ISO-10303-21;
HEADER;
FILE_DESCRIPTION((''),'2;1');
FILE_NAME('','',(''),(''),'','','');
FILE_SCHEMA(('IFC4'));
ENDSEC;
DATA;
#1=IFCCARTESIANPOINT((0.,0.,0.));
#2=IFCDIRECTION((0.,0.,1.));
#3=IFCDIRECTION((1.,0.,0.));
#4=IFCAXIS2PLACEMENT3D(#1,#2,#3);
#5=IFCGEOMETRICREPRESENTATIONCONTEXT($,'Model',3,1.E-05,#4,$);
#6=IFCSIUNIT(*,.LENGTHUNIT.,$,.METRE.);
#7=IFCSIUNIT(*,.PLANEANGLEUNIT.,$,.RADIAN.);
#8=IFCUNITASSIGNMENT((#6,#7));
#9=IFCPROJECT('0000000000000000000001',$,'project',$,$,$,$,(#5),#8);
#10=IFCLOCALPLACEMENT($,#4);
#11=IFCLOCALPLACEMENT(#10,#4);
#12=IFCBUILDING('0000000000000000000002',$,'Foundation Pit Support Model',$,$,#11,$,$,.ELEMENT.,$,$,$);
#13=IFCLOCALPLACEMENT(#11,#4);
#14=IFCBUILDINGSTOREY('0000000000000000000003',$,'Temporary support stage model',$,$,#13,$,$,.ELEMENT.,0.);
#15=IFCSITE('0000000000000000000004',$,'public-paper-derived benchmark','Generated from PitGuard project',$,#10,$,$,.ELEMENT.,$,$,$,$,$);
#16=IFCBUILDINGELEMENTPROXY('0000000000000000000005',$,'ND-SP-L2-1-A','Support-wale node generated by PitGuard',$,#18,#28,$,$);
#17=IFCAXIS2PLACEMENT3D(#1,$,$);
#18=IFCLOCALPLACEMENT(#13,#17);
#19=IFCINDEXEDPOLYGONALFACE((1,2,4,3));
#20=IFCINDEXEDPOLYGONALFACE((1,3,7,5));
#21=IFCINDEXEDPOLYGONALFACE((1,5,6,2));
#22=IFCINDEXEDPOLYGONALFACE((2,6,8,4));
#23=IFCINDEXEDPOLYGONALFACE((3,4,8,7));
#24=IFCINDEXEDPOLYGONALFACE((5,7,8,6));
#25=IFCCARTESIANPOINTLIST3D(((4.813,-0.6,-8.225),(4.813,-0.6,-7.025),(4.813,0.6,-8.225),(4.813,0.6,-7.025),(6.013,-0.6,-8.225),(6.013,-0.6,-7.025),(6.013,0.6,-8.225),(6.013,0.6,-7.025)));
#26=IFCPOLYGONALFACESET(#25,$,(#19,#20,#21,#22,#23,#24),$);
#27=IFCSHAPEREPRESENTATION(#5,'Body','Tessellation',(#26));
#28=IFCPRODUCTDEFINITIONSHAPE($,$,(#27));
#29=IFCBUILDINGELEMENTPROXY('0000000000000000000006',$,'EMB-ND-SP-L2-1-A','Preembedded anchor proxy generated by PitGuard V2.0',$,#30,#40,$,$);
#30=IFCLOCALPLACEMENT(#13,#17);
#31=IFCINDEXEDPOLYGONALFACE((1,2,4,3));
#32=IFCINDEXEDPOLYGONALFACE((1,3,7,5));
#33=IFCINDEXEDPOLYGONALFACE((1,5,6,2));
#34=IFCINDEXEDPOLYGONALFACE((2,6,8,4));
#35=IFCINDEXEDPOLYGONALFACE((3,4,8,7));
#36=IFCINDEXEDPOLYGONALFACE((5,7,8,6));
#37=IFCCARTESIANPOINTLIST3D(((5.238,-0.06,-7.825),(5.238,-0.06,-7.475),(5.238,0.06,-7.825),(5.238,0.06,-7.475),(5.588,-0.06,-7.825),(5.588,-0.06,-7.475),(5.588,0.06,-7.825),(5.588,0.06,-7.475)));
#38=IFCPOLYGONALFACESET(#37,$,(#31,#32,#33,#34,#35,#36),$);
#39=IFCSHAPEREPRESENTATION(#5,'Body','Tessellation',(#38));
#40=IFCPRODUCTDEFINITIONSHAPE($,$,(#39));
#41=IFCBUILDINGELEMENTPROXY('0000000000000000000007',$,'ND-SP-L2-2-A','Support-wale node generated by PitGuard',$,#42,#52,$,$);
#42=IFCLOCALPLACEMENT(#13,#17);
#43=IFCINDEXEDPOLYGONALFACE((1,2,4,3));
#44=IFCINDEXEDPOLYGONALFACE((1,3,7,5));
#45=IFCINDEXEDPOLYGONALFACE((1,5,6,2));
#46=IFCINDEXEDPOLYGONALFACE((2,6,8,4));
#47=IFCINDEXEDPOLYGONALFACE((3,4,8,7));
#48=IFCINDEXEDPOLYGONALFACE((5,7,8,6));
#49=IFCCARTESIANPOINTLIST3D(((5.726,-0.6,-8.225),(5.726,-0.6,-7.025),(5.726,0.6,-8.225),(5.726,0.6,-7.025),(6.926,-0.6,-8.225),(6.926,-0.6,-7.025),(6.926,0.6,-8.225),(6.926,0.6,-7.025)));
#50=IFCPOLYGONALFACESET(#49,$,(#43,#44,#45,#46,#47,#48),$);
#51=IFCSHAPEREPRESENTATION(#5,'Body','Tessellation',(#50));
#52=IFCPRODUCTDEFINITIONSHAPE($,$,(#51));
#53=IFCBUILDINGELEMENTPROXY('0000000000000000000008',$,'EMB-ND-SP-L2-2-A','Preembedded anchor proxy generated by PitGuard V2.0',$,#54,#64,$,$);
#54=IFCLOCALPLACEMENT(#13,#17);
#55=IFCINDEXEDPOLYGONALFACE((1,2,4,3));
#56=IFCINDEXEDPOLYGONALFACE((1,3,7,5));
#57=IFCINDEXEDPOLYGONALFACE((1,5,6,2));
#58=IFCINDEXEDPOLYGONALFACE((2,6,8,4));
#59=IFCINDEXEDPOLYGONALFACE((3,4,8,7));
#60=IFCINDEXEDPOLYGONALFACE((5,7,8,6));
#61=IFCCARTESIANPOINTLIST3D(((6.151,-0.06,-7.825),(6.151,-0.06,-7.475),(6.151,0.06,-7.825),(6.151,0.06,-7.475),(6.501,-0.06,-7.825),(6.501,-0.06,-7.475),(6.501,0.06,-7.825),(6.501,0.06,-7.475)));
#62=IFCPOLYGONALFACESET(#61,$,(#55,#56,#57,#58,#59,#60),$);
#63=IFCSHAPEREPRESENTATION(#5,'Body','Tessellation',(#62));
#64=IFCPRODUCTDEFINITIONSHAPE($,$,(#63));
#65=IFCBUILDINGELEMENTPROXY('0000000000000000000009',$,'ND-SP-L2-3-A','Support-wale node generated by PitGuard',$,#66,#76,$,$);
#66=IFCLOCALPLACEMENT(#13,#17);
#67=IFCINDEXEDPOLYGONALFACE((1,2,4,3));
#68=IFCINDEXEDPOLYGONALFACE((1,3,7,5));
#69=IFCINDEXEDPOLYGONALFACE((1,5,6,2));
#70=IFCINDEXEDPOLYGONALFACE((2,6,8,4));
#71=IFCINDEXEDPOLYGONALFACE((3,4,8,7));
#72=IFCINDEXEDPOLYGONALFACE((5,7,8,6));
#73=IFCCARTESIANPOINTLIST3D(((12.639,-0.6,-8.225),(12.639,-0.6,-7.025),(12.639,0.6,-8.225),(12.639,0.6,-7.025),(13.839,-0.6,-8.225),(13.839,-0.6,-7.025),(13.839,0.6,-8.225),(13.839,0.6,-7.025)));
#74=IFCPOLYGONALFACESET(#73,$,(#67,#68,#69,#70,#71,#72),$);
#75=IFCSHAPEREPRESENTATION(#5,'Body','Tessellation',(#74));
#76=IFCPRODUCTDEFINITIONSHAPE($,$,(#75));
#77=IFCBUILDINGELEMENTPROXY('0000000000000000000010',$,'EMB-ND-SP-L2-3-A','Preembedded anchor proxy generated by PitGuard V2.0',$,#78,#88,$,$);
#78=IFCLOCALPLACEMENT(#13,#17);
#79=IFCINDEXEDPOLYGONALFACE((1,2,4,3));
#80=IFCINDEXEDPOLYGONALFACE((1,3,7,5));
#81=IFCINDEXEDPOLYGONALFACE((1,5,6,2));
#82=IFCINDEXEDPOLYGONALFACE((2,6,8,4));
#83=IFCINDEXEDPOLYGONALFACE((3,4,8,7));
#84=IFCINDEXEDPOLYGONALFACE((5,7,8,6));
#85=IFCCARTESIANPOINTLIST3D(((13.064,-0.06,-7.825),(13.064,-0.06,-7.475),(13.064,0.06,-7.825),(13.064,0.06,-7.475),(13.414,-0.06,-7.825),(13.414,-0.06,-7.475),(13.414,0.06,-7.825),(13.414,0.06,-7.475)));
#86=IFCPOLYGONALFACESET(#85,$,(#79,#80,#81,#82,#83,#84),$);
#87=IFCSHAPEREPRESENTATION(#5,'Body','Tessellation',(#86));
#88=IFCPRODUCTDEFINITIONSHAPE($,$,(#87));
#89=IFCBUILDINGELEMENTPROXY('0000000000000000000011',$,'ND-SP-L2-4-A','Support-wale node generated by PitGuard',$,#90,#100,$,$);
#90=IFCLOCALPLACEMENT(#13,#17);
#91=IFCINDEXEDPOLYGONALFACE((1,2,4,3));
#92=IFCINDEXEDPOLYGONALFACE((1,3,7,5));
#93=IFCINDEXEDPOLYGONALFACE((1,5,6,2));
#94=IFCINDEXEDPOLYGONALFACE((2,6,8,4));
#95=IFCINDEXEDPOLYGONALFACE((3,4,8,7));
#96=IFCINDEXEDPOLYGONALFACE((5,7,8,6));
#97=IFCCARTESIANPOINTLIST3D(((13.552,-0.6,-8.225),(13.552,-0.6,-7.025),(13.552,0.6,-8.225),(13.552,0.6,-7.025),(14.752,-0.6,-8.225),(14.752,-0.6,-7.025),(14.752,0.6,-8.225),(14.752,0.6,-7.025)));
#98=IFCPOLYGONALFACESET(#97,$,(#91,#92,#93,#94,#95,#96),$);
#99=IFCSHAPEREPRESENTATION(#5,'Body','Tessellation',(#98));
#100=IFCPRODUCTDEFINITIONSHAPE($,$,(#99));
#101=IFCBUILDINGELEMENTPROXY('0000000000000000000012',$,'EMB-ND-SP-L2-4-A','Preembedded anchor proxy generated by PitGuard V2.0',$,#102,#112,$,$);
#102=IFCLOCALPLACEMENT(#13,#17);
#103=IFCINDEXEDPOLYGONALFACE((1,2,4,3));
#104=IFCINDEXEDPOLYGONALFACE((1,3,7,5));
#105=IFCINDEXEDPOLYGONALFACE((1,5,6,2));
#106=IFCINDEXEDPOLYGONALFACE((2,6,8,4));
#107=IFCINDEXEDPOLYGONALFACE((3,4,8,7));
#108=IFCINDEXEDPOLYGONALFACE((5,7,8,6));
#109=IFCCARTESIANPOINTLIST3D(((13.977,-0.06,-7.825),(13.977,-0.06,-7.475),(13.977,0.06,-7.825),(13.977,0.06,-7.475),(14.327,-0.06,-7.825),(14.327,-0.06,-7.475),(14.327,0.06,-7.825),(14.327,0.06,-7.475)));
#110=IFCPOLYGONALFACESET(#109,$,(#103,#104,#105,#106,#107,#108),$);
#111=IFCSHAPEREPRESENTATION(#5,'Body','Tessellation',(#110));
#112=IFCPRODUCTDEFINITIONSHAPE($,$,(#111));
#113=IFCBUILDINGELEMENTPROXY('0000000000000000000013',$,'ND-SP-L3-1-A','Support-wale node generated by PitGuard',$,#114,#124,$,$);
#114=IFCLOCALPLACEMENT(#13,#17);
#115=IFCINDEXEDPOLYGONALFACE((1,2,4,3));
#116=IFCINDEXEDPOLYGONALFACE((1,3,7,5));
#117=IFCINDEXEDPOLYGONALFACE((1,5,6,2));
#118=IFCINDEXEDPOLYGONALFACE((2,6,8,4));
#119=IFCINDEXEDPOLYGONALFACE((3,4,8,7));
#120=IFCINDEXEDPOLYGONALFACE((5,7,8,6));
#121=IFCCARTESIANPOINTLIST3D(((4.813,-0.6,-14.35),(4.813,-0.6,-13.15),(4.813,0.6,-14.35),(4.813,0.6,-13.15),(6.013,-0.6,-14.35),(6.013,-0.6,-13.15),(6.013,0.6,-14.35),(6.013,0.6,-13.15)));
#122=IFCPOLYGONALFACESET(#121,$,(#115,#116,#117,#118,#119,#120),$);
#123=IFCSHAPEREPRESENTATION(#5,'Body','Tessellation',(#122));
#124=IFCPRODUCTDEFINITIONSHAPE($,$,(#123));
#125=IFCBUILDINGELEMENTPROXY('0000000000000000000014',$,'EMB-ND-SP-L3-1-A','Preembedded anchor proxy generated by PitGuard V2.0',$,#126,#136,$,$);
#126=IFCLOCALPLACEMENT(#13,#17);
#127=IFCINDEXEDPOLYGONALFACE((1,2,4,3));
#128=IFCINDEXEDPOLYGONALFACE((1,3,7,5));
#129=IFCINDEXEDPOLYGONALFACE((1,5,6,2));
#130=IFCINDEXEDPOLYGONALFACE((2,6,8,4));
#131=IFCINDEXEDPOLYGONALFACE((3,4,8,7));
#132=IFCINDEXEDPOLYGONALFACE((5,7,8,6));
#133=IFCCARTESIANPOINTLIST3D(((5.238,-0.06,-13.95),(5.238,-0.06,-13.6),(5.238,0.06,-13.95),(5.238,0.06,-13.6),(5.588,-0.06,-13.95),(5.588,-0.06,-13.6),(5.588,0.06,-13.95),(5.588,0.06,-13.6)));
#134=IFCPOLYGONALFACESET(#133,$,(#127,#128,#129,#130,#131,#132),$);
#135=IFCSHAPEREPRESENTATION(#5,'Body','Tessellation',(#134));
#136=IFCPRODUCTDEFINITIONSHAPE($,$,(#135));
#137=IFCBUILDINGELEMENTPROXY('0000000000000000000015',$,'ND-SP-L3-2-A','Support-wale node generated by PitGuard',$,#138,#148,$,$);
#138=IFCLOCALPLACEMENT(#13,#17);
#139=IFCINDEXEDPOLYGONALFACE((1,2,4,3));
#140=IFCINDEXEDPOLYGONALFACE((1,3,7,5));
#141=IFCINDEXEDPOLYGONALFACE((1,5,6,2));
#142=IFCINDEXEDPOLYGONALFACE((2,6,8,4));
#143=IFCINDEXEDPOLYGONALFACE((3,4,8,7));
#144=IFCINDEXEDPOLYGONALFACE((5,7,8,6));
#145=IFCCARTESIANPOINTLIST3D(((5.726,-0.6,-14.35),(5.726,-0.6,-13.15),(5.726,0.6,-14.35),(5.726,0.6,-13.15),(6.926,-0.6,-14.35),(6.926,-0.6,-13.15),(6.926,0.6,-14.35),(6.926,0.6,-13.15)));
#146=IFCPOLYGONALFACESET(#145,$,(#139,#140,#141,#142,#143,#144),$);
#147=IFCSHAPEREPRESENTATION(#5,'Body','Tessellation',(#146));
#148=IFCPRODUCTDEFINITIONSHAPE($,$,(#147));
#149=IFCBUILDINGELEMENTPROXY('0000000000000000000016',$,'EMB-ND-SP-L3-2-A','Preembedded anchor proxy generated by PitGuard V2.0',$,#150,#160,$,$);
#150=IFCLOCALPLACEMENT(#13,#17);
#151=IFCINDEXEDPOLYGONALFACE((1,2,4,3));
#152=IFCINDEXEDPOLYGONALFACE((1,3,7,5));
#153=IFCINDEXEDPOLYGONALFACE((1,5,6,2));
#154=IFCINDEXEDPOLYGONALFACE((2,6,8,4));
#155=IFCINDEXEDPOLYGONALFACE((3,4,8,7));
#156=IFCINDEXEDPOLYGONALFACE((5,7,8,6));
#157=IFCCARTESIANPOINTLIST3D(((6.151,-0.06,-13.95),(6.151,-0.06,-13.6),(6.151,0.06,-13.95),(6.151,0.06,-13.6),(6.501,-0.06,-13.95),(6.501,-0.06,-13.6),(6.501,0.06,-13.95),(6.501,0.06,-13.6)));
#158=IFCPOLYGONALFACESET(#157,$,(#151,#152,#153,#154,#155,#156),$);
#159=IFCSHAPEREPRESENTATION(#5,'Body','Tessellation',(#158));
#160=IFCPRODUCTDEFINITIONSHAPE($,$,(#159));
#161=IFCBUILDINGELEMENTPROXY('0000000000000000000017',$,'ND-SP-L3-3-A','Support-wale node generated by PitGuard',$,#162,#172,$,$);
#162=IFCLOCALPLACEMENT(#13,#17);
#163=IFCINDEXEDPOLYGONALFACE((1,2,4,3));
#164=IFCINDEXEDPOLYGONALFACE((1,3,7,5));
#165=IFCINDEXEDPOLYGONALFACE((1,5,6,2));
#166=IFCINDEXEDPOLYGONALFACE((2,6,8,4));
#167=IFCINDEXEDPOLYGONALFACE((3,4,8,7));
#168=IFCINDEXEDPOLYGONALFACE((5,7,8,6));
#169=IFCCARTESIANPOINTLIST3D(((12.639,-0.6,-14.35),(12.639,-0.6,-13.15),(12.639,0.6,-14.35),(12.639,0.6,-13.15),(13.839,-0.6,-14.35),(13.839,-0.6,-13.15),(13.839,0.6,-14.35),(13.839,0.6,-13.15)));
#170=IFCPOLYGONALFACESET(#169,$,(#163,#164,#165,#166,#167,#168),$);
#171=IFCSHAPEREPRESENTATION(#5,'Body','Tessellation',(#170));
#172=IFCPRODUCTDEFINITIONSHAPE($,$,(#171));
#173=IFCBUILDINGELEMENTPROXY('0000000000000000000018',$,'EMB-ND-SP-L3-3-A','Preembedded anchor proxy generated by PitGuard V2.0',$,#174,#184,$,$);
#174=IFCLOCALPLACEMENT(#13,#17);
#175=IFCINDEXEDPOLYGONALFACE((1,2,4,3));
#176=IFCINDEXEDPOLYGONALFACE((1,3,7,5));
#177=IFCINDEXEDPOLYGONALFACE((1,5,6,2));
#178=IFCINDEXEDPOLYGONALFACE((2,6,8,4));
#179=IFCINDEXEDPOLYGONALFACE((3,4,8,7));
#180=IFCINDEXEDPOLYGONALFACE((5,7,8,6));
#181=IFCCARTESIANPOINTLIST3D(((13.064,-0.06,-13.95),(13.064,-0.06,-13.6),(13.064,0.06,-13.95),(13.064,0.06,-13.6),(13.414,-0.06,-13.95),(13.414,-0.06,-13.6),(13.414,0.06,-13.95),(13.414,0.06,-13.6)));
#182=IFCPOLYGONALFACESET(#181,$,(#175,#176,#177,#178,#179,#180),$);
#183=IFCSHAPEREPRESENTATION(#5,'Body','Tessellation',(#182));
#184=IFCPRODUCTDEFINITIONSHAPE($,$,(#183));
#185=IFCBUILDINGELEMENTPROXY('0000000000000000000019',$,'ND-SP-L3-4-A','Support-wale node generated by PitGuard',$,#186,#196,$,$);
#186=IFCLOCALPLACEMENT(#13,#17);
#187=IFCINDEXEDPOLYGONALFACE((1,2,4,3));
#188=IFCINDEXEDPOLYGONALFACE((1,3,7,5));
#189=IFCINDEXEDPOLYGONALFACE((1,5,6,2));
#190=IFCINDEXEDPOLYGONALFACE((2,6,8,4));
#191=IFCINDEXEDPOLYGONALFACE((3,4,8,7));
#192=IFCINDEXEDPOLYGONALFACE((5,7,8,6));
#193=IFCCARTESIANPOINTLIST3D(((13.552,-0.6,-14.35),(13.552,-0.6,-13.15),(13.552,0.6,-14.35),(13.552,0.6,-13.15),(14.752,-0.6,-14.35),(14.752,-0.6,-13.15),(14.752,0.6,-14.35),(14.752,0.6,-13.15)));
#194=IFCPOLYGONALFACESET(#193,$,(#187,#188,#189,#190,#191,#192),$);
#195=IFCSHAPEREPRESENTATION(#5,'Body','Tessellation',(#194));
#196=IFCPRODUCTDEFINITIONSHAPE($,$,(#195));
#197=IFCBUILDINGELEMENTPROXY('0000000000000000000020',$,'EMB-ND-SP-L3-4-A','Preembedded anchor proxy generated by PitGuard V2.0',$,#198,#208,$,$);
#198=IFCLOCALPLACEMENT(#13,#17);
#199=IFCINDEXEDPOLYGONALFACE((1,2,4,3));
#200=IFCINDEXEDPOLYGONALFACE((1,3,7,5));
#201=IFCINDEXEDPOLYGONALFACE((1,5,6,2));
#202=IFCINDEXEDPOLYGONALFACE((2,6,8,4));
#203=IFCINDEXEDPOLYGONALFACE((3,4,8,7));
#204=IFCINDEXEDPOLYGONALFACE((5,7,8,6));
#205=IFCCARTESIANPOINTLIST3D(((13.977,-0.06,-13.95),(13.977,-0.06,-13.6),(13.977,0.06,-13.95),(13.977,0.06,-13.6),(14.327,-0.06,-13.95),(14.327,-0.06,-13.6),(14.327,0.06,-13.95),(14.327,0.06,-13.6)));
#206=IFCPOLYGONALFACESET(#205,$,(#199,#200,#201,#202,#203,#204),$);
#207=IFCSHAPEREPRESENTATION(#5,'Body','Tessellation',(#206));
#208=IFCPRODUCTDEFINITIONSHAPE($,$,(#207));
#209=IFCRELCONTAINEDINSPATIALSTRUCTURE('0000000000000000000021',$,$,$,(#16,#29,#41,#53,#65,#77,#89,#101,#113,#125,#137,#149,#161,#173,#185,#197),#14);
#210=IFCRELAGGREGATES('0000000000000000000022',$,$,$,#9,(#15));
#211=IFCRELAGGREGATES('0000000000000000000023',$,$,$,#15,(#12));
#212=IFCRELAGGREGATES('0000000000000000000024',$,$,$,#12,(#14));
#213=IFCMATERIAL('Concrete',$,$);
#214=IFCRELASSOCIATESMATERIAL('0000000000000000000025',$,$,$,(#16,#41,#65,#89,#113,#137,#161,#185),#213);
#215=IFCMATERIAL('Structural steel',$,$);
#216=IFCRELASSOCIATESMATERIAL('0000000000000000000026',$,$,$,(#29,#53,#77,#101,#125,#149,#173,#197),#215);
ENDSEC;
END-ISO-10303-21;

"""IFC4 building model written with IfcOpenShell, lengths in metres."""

from ifc_helpers import new_model, si_unit, frame, origin_with_axes, origin_2d, place, context, project, spatial, rectangle, extrude, material, element, save


model = new_model("IFC4")

# Units and contexts
model_context = context("Model", 3, precision=1e-05, world=origin_with_axes())
ifc_project = project(units=[si_unit("LENGTHUNIT", "METRE"), si_unit("PLANEANGLEUNIT", "RADIAN")], contexts=[model_context])

# Site, building, storey
site_placement = place(None, origin_with_axes())
site = spatial("IfcSite", under=ifc_project, at=site_placement, Name="public-paper-derived benchmark", Description="Generated from PitGuard project", CompositionType="ELEMENT")
building_placement = place(site_placement, origin_with_axes())
building = spatial("IfcBuilding", under=site, at=building_placement, Name="Foundation Pit Support Model", CompositionType="ELEMENT")
storey_placement = place(building_placement, origin_with_axes())
storey = spatial("IfcBuildingStorey", under=building, at=storey_placement, Name="Temporary support stage model", CompositionType="ELEMENT", Elevation=0.0)

# Shared definitions
ifc_material_1 = material(Name="Structural steel")

# Building element proxies
ifc_material_2 = material(Name="Concrete")
for number, where, z_axis, x_axis, name in (
    (1, (5.413, 0.0, -8.225), (0.0, 0.0, 1.0), (1.0, 0.0, 0.0), "ND-SP-L2-1-A"),
):
    element("IfcBuildingElementProxy", number, at=place(storey_placement, frame(where, z_axis=z_axis, x_axis=x_axis)), inside=storey, material=ifc_material_2, Name=name, Description="Support-wale node generated by PitGuard", context=model_context, shape_type="SweptSolid", body=[
        extrude(rectangle(XDim=1.2, YDim=1.2, at=origin_2d()), origin_with_axes(), (0.0, 0.0, 1.0), 1.2),
    ])
proxy_1_placement = place(storey_placement, frame((5.413, 0.0, -7.825), z_axis=(0.0, 0.0, 1.0), x_axis=(1.0, 0.0, 0.0)))
element("IfcBuildingElementProxy", 2, at=proxy_1_placement, inside=storey, material=ifc_material_1, Name="EMB-ND-SP-L2-1-A", Description="Preembedded anchor proxy generated by PitGuard V2.0", context=model_context, shape_type="SweptSolid", body=[
    extrude(rectangle(XDim=0.35, YDim=0.12, at=origin_2d()), origin_with_axes(), (0.0, 0.0, 1.0), 0.35),
])
proxy_2_placement = place(storey_placement, frame((6.326, 0.0, -8.225), z_axis=(0.0, 0.0, 1.0), x_axis=(1.0, 0.0, 0.0)))
element("IfcBuildingElementProxy", 3, at=proxy_2_placement, inside=storey, material=ifc_material_2, Name="ND-SP-L2-2-A", Description="Support-wale node generated by PitGuard", context=model_context, shape_type="SweptSolid", body=[
    extrude(rectangle(XDim=1.2, YDim=1.2, at=origin_2d()), origin_with_axes(), (0.0, 0.0, 1.0), 1.2),
])
proxy_3_placement = place(storey_placement, frame((6.326, 0.0, -7.825), z_axis=(0.0, 0.0, 1.0), x_axis=(1.0, 0.0, 0.0)))
element("IfcBuildingElementProxy", 4, at=proxy_3_placement, inside=storey, material=ifc_material_1, Name="EMB-ND-SP-L2-2-A", Description="Preembedded anchor proxy generated by PitGuard V2.0", context=model_context, shape_type="SweptSolid", body=[
    extrude(rectangle(XDim=0.35, YDim=0.12, at=origin_2d()), origin_with_axes(), (0.0, 0.0, 1.0), 0.35),
])
proxy_4_placement = place(storey_placement, frame((13.239, 0.0, -8.225), z_axis=(0.0, 0.0, 1.0), x_axis=(1.0, 0.0, 0.0)))
element("IfcBuildingElementProxy", 5, at=proxy_4_placement, inside=storey, material=ifc_material_2, Name="ND-SP-L2-3-A", Description="Support-wale node generated by PitGuard", context=model_context, shape_type="SweptSolid", body=[
    extrude(rectangle(XDim=1.2, YDim=1.2, at=origin_2d()), origin_with_axes(), (0.0, 0.0, 1.0), 1.2),
])
proxy_5_placement = place(storey_placement, frame((13.239, 0.0, -7.825), z_axis=(0.0, 0.0, 1.0), x_axis=(1.0, 0.0, 0.0)))
element("IfcBuildingElementProxy", 6, at=proxy_5_placement, inside=storey, material=ifc_material_1, Name="EMB-ND-SP-L2-3-A", Description="Preembedded anchor proxy generated by PitGuard V2.0", context=model_context, shape_type="SweptSolid", body=[
    extrude(rectangle(XDim=0.35, YDim=0.12, at=origin_2d()), origin_with_axes(), (0.0, 0.0, 1.0), 0.35),
])
proxy_6_placement = place(storey_placement, frame((14.152, 0.0, -8.225), z_axis=(0.0, 0.0, 1.0), x_axis=(1.0, 0.0, 0.0)))
element("IfcBuildingElementProxy", 7, at=proxy_6_placement, inside=storey, material=ifc_material_2, Name="ND-SP-L2-4-A", Description="Support-wale node generated by PitGuard", context=model_context, shape_type="SweptSolid", body=[
    extrude(rectangle(XDim=1.2, YDim=1.2, at=origin_2d()), origin_with_axes(), (0.0, 0.0, 1.0), 1.2),
])
proxy_7_placement = place(storey_placement, frame((14.152, 0.0, -7.825), z_axis=(0.0, 0.0, 1.0), x_axis=(1.0, 0.0, 0.0)))
element("IfcBuildingElementProxy", 8, at=proxy_7_placement, inside=storey, material=ifc_material_1, Name="EMB-ND-SP-L2-4-A", Description="Preembedded anchor proxy generated by PitGuard V2.0", context=model_context, shape_type="SweptSolid", body=[
    extrude(rectangle(XDim=0.35, YDim=0.12, at=origin_2d()), origin_with_axes(), (0.0, 0.0, 1.0), 0.35),
])
proxy_8_placement = place(storey_placement, frame((5.413, 0.0, -14.35), z_axis=(0.0, 0.0, 1.0), x_axis=(1.0, 0.0, 0.0)))
element("IfcBuildingElementProxy", 9, at=proxy_8_placement, inside=storey, material=ifc_material_2, Name="ND-SP-L3-1-A", Description="Support-wale node generated by PitGuard", context=model_context, shape_type="SweptSolid", body=[
    extrude(rectangle(XDim=1.2, YDim=1.2, at=origin_2d()), origin_with_axes(), (0.0, 0.0, 1.0), 1.2),
])
proxy_9_placement = place(storey_placement, frame((5.413, 0.0, -13.95), z_axis=(0.0, 0.0, 1.0), x_axis=(1.0, 0.0, 0.0)))
element("IfcBuildingElementProxy", 10, at=proxy_9_placement, inside=storey, material=ifc_material_1, Name="EMB-ND-SP-L3-1-A", Description="Preembedded anchor proxy generated by PitGuard V2.0", context=model_context, shape_type="SweptSolid", body=[
    extrude(rectangle(XDim=0.35, YDim=0.12, at=origin_2d()), origin_with_axes(), (0.0, 0.0, 1.0), 0.35),
])
proxy_10_placement = place(storey_placement, frame((6.326, 0.0, -14.35), z_axis=(0.0, 0.0, 1.0), x_axis=(1.0, 0.0, 0.0)))
element("IfcBuildingElementProxy", 11, at=proxy_10_placement, inside=storey, material=ifc_material_2, Name="ND-SP-L3-2-A", Description="Support-wale node generated by PitGuard", context=model_context, shape_type="SweptSolid", body=[
    extrude(rectangle(XDim=1.2, YDim=1.2, at=origin_2d()), origin_with_axes(), (0.0, 0.0, 1.0), 1.2),
])
proxy_11_placement = place(storey_placement, frame((6.326, 0.0, -13.95), z_axis=(0.0, 0.0, 1.0), x_axis=(1.0, 0.0, 0.0)))
element("IfcBuildingElementProxy", 12, at=proxy_11_placement, inside=storey, material=ifc_material_1, Name="EMB-ND-SP-L3-2-A", Description="Preembedded anchor proxy generated by PitGuard V2.0", context=model_context, shape_type="SweptSolid", body=[
    extrude(rectangle(XDim=0.35, YDim=0.12, at=origin_2d()), origin_with_axes(), (0.0, 0.0, 1.0), 0.35),
])
proxy_12_placement = place(storey_placement, frame((13.239, 0.0, -14.35), z_axis=(0.0, 0.0, 1.0), x_axis=(1.0, 0.0, 0.0)))
element("IfcBuildingElementProxy", 13, at=proxy_12_placement, inside=storey, material=ifc_material_2, Name="ND-SP-L3-3-A", Description="Support-wale node generated by PitGuard", context=model_context, shape_type="SweptSolid", body=[
    extrude(rectangle(XDim=1.2, YDim=1.2, at=origin_2d()), origin_with_axes(), (0.0, 0.0, 1.0), 1.2),
])
proxy_13_placement = place(storey_placement, frame((13.239, 0.0, -13.95), z_axis=(0.0, 0.0, 1.0), x_axis=(1.0, 0.0, 0.0)))
element("IfcBuildingElementProxy", 14, at=proxy_13_placement, inside=storey, material=ifc_material_1, Name="EMB-ND-SP-L3-3-A", Description="Preembedded anchor proxy generated by PitGuard V2.0", context=model_context, shape_type="SweptSolid", body=[
    extrude(rectangle(XDim=0.35, YDim=0.12, at=origin_2d()), origin_with_axes(), (0.0, 0.0, 1.0), 0.35),
])
proxy_14_placement = place(storey_placement, frame((14.152, 0.0, -14.35), z_axis=(0.0, 0.0, 1.0), x_axis=(1.0, 0.0, 0.0)))
element("IfcBuildingElementProxy", 15, at=proxy_14_placement, inside=storey, material=ifc_material_2, Name="ND-SP-L3-4-A", Description="Support-wale node generated by PitGuard", context=model_context, shape_type="SweptSolid", body=[
    extrude(rectangle(XDim=1.2, YDim=1.2, at=origin_2d()), origin_with_axes(), (0.0, 0.0, 1.0), 1.2),
])
proxy_15_placement = place(storey_placement, frame((14.152, 0.0, -13.95), z_axis=(0.0, 0.0, 1.0), x_axis=(1.0, 0.0, 0.0)))
element("IfcBuildingElementProxy", 16, at=proxy_15_placement, inside=storey, material=ifc_material_1, Name="EMB-ND-SP-L3-4-A", Description="Preembedded anchor proxy generated by PitGuard V2.0", context=model_context, shape_type="SweptSolid", body=[
    extrude(rectangle(XDim=0.35, YDim=0.12, at=origin_2d()), origin_with_axes(), (0.0, 0.0, 1.0), 0.35),
])

save(model, "model.ifc")
